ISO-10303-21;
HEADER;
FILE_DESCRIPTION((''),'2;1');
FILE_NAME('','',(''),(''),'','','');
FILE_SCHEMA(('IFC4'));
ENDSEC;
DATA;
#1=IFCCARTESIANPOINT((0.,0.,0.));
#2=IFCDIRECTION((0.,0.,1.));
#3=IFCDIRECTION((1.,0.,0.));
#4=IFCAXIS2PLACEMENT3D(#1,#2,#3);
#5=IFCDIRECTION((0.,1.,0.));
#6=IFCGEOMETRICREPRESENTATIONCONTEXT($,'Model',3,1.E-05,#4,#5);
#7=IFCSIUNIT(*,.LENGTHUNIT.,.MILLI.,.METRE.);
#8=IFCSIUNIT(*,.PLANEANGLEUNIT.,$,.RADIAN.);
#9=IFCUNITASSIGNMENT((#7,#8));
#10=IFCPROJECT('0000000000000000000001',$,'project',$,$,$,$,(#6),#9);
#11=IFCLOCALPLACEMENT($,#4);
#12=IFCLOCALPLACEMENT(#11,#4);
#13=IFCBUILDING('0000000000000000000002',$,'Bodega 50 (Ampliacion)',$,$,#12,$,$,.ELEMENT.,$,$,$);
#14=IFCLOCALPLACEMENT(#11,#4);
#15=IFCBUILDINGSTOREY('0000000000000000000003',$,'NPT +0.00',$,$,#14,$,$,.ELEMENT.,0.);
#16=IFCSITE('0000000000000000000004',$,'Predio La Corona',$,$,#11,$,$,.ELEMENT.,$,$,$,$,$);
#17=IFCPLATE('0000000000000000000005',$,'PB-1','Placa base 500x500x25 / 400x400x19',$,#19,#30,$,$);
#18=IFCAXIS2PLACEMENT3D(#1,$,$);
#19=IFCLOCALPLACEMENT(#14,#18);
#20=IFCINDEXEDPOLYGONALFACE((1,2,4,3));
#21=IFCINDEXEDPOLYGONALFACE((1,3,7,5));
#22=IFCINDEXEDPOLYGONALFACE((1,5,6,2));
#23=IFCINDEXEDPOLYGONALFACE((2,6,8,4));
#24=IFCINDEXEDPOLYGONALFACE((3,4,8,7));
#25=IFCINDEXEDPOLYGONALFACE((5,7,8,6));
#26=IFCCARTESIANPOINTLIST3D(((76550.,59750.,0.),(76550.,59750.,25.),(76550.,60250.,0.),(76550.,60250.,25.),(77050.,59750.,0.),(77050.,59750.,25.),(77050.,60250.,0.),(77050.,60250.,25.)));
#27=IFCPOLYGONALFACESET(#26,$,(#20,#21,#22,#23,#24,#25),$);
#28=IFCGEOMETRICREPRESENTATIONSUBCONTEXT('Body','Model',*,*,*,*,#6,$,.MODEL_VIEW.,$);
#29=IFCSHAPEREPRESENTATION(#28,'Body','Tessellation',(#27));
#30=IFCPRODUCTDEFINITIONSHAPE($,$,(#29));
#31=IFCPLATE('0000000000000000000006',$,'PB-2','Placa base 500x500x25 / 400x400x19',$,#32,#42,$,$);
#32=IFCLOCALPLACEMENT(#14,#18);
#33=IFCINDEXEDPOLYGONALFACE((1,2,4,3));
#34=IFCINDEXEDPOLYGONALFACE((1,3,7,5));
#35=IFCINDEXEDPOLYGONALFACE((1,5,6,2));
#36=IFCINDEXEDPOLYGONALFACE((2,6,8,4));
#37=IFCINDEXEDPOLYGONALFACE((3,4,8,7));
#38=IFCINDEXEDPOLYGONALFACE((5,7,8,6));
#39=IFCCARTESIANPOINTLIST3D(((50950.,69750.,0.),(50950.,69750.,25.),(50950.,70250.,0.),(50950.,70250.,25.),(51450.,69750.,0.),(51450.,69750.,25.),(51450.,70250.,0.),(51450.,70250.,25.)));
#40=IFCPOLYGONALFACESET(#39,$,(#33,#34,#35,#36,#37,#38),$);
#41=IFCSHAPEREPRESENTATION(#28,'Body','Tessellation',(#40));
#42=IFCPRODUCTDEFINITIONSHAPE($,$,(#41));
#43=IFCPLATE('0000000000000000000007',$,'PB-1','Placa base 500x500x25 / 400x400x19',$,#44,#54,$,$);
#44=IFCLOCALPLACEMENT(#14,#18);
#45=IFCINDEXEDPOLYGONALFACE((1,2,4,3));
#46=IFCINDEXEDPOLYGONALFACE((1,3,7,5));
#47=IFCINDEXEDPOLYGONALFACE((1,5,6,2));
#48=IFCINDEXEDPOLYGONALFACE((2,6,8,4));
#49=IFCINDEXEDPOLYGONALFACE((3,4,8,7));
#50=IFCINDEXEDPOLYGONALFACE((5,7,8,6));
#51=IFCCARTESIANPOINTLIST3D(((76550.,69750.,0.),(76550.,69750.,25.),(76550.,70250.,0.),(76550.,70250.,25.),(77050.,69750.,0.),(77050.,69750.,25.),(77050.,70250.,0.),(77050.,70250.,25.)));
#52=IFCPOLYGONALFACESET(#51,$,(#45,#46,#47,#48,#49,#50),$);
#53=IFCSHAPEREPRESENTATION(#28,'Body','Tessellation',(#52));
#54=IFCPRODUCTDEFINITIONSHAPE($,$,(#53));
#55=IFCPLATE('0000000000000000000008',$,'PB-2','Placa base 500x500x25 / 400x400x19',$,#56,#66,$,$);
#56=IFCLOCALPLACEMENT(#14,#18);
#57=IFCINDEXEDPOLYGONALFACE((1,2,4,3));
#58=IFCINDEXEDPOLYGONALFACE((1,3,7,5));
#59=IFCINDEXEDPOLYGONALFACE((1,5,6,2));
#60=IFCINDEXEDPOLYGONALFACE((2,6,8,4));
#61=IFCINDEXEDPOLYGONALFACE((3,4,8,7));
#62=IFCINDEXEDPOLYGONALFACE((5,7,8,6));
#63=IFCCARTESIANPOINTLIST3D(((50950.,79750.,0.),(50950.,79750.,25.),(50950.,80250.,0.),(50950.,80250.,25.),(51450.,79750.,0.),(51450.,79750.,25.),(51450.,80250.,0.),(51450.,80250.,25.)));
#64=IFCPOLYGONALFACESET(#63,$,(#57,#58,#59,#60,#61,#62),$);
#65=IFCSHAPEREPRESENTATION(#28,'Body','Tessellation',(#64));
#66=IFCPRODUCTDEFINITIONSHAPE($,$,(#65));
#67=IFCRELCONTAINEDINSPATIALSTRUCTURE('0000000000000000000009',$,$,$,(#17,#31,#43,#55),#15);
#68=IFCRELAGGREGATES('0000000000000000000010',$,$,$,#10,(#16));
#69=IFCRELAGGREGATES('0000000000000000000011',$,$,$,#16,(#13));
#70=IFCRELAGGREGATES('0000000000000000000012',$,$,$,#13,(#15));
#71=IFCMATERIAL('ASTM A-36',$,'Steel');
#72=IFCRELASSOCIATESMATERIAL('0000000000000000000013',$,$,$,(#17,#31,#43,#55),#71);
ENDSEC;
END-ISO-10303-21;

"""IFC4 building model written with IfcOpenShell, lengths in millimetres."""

from ifc_helpers import new_model, si_unit, direction, frame, origin_with_axes, origin_2d, place, context, subcontext, project, spatial, rectangle, extrude, material, element, save


model = new_model("IFC4")

# Units and contexts
model_context = context("Model", 3, precision=1e-05, world=origin_with_axes(), true_north=direction((0.0, 1.0, 0.0)))
body_context = subcontext(model_context, "Body", "Model", "MODEL_VIEW")
ifc_project = project(units=[si_unit("LENGTHUNIT", "METRE", prefix="MILLI"), si_unit("PLANEANGLEUNIT", "RADIAN")], contexts=[model_context])

# Site, building, storey
site_placement = place(None, origin_with_axes())
site = spatial("IfcSite", under=ifc_project, at=site_placement, Name="Predio La Corona", CompositionType="ELEMENT")
building_placement = place(site_placement, origin_with_axes())
building = spatial("IfcBuilding", under=site, at=building_placement, Name="Bodega 50 (Ampliacion)", CompositionType="ELEMENT")
storey_placement = place(site_placement, origin_with_axes())
storey = spatial("IfcBuildingStorey", under=building, at=storey_placement, Name="NPT +0.00", CompositionType="ELEMENT", Elevation=0.0)

# Shared definitions
ifc_material = material(Name="ASTM A-36", Category="Steel")

# Plates
for number, where, z_axis, x_axis, name in (
    (1, (76800.0, 60000.0, 0.0), (0.0, 0.0, 1.0), (1.0, 0.0, 0.0), "PB-1"),
    (2, (51200.0, 70000.0, 0.0), (0.0, 0.0, 1.0), (1.0, 0.0, 0.0), "PB-2"),
    (3, (76800.0, 70000.0, 0.0), (0.0, 0.0, 1.0), (1.0, 0.0, 0.0), "PB-1"),
    (4, (51200.0, 80000.0, 0.0), (0.0, 0.0, 1.0), (1.0, 0.0, 0.0), "PB-2"),
):
    element("IfcPlate", number, at=place(storey_placement, frame(where, z_axis=z_axis, x_axis=x_axis)), inside=storey, material=ifc_material, Name=name, Description="Placa base 500x500x25 / 400x400x19", context=body_context, shape_type="SweptSolid", body=[
        extrude(rectangle(XDim=500.0, YDim=500.0, at=origin_2d()), origin_with_axes(), (0.0, 0.0, 1.0), 25.0),
    ])

save(model, "model.ifc")
